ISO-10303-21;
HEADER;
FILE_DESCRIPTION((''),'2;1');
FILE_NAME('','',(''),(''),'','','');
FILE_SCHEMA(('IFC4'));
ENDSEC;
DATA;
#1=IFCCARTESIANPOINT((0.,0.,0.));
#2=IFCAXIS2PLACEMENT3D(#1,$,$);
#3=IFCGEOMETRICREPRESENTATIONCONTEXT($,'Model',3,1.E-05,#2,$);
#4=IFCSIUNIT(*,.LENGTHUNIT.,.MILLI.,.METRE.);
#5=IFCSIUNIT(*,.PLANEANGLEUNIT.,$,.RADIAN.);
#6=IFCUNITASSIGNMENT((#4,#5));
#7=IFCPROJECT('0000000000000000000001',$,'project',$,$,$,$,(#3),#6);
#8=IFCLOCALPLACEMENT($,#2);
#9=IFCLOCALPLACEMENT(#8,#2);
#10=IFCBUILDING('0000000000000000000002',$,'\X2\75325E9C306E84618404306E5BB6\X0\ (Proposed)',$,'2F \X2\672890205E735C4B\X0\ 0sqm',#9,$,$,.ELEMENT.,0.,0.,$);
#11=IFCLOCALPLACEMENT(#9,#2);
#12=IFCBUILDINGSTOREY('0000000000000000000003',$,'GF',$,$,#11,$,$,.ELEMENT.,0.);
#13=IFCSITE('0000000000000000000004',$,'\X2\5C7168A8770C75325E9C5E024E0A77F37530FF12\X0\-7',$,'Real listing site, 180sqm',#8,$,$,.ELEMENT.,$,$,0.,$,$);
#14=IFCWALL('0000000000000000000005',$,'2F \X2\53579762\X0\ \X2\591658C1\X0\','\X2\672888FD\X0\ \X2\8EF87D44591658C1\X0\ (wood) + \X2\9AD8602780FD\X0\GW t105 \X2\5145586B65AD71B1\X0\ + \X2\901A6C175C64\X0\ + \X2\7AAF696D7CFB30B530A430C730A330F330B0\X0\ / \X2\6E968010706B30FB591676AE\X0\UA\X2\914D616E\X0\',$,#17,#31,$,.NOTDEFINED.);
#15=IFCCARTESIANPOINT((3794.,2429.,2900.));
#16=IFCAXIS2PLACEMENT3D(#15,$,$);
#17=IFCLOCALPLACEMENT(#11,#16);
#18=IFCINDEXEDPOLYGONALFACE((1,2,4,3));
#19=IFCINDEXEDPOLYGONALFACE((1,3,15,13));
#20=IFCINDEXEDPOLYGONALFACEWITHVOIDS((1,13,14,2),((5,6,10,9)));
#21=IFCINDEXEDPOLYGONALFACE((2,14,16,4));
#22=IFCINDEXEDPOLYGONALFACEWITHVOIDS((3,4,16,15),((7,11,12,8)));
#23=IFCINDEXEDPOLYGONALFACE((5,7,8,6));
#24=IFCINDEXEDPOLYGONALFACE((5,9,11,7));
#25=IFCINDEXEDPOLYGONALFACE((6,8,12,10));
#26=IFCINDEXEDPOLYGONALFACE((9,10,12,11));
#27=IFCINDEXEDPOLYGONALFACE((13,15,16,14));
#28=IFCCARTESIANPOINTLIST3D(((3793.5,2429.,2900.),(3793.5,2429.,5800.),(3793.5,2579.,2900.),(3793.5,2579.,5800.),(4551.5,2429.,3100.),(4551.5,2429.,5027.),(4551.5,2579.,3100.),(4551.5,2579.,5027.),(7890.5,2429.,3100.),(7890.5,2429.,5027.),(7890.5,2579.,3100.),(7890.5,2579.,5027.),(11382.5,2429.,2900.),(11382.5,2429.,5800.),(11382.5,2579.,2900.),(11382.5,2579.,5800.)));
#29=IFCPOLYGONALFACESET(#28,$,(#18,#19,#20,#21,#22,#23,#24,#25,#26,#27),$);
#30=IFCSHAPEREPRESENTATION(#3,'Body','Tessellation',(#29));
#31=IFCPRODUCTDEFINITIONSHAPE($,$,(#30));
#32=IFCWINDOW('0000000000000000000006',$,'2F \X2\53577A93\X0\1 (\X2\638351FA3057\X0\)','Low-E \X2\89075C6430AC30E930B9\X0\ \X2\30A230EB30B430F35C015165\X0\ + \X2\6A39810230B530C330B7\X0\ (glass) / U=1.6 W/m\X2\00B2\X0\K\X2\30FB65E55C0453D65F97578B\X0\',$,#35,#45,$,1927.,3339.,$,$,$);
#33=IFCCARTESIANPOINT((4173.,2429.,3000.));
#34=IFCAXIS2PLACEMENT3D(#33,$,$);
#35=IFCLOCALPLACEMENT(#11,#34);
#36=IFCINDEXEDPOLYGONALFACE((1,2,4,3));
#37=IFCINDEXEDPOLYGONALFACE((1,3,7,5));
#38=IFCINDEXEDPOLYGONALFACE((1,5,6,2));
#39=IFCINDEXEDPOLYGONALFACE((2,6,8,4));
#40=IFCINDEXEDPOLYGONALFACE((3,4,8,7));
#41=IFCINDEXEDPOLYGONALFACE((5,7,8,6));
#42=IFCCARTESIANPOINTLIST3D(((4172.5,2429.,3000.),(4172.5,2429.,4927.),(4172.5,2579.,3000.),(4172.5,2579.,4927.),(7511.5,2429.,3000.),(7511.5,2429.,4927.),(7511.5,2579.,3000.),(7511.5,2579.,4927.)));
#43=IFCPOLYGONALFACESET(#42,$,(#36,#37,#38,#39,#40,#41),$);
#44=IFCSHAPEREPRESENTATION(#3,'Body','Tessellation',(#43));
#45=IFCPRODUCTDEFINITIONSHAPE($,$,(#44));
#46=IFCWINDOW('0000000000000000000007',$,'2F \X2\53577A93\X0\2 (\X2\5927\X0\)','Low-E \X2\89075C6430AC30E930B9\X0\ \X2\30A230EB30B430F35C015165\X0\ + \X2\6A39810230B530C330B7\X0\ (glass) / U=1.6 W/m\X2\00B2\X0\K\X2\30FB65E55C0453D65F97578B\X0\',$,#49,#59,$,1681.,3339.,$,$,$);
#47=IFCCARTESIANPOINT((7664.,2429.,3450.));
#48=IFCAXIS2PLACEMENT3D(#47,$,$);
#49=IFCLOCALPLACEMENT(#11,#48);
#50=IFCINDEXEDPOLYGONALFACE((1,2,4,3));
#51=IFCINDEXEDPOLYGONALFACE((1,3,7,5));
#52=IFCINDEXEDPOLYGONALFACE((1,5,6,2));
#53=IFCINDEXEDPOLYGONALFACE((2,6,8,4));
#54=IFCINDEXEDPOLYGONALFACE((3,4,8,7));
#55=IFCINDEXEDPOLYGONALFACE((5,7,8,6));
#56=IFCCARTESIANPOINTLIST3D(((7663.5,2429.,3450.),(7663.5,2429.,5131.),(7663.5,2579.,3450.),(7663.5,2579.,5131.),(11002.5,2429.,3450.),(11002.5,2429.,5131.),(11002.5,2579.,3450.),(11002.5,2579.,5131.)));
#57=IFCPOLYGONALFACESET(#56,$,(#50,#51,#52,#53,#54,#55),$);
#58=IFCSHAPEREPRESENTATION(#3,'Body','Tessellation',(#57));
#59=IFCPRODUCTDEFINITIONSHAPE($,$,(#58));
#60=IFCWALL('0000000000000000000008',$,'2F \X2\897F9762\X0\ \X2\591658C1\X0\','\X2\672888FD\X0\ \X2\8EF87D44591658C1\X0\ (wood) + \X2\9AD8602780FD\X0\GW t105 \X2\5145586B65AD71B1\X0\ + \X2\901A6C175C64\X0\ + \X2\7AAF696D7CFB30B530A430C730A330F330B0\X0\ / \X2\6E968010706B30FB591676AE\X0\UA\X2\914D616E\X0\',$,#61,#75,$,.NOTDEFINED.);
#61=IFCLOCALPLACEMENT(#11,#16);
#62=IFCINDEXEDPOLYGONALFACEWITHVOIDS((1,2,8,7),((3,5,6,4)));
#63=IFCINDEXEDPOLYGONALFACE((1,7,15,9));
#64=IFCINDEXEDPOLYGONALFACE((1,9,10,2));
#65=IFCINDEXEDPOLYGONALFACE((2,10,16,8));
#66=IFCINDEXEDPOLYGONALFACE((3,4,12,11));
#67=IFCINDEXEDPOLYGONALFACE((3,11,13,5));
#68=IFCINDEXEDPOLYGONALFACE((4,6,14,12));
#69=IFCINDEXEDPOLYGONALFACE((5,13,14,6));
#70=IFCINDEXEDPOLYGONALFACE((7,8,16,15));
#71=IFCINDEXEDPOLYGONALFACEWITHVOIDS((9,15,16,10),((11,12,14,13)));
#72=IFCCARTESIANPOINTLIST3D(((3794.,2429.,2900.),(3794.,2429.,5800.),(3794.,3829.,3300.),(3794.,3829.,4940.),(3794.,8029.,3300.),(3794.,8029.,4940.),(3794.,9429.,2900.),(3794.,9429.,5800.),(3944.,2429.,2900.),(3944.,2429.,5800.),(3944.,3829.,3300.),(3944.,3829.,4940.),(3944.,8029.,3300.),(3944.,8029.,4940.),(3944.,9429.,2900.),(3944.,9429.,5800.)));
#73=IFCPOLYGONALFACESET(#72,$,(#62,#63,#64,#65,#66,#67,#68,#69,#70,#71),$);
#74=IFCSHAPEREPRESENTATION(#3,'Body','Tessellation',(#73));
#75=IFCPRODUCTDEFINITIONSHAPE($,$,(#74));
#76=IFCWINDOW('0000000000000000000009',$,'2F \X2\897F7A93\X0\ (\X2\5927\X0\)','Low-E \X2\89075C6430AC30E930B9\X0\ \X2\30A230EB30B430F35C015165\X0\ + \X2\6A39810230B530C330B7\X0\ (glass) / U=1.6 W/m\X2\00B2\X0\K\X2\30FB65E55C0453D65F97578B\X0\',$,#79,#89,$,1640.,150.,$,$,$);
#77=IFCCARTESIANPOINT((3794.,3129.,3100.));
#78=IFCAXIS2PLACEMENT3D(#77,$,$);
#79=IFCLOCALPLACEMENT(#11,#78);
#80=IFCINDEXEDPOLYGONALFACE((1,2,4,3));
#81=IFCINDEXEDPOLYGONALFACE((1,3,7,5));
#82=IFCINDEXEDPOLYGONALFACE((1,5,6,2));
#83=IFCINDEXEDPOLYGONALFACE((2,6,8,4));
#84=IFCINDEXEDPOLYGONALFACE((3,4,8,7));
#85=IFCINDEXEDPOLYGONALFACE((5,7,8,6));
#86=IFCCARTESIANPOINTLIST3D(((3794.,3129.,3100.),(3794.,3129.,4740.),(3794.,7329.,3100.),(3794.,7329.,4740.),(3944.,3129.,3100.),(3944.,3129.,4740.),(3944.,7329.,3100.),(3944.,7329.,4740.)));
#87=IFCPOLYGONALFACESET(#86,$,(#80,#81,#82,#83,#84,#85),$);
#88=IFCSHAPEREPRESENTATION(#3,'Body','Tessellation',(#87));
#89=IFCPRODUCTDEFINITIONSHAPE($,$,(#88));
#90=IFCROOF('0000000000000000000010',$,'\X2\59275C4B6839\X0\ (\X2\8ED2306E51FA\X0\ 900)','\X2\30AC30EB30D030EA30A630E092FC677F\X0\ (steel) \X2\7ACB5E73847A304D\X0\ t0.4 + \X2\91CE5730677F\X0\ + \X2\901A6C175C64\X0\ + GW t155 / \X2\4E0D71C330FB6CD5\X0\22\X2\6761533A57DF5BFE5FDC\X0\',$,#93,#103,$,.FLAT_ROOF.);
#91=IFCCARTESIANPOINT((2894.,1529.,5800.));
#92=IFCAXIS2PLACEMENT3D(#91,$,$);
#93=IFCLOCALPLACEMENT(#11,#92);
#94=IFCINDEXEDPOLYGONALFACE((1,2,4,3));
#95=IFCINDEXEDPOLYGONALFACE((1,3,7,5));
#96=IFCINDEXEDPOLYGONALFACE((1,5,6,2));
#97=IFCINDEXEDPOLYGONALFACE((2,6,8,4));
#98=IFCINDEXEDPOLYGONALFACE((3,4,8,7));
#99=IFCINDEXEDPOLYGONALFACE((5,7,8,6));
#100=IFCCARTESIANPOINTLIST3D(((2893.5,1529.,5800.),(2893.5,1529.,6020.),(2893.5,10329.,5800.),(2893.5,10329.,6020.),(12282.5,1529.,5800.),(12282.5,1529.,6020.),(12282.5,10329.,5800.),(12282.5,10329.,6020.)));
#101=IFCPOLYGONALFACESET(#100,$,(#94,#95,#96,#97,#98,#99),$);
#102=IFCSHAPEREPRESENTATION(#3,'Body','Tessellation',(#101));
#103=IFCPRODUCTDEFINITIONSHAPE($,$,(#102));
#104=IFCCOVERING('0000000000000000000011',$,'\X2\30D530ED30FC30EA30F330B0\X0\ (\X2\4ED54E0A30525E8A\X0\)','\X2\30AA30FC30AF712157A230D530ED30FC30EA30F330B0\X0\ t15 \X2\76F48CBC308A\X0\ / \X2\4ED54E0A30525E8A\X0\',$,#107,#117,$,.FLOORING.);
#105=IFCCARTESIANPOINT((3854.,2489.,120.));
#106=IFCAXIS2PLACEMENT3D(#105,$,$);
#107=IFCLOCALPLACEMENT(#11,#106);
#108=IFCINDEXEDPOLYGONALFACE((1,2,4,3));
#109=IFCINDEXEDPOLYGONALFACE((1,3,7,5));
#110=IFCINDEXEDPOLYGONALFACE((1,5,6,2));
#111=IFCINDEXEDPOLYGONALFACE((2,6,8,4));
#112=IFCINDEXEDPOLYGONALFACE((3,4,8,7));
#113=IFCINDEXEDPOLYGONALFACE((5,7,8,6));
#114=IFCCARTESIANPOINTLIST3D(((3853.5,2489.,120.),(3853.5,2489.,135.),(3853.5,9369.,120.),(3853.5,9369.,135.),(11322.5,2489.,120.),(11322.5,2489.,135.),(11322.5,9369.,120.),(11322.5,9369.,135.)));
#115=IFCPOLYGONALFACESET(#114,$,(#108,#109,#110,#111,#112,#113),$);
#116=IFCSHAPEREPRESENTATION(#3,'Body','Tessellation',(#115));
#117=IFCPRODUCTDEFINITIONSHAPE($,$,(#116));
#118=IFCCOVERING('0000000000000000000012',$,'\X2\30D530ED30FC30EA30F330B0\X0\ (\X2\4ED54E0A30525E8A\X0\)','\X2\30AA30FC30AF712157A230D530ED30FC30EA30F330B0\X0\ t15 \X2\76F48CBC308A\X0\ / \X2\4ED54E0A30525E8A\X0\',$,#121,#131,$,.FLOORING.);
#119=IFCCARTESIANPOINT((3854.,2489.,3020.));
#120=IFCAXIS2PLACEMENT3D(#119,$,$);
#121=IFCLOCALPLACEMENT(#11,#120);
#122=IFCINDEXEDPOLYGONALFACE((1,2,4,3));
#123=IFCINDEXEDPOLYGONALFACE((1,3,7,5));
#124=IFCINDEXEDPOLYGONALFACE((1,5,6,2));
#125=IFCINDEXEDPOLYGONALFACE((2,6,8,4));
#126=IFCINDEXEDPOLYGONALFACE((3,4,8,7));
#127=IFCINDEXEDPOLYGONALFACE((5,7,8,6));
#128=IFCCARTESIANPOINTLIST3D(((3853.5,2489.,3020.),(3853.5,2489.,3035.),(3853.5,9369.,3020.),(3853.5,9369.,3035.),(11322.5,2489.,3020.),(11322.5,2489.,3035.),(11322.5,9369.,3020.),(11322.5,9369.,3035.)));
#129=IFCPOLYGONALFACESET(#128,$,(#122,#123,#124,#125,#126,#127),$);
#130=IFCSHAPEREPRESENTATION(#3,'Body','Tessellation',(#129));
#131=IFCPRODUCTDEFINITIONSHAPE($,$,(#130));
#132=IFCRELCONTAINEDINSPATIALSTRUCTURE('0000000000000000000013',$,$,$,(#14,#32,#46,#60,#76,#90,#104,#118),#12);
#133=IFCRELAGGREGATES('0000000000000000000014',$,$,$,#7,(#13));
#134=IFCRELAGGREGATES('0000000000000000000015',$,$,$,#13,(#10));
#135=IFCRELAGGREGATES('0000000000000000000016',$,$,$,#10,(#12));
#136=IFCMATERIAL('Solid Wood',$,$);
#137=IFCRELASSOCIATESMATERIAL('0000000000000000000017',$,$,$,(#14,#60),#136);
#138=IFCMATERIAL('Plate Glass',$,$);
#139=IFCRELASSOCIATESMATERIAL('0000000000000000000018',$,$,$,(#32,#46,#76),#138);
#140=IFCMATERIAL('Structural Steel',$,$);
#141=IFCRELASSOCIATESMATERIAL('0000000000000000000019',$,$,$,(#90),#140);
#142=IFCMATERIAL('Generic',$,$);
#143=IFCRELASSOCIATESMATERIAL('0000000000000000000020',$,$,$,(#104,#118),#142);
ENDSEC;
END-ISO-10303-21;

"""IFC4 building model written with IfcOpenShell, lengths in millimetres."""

from ifc_helpers import new_model, si_unit, frame, frame_2d, origin, place, context, project, spatial, rectangle, extrude, material, element, fill, save


model = new_model("IFC4")

# Units and contexts
model_context = context("Model", 3, precision=1e-05, world=origin())
ifc_project = project(units=[si_unit("LENGTHUNIT", "METRE", prefix="MILLI"), si_unit("PLANEANGLEUNIT", "RADIAN")], contexts=[model_context])

# Site, building, storey
site_placement = place(None, origin())
site = spatial("IfcSite", under=ifc_project, at=site_placement, Name="山梨県甲府市上石田２-7", ObjectType="Real listing site, 180sqm", CompositionType="ELEMENT", RefElevation=0.0)
building_placement = place(site_placement, origin())
building = spatial("IfcBuilding", under=site, at=building_placement, Name="甲府の葡萄の家 (Proposed)", ObjectType="2F 木造平屋 0sqm", CompositionType="ELEMENT", ElevationOfRefHeight=0.0, ElevationOfTerrain=0.0)
storey_placement = place(building_placement, origin())
storey = spatial("IfcBuildingStorey", under=building, at=storey_placement, Name="GF", CompositionType="ELEMENT", Elevation=0.0)

# Shared definitions
ifc_material_1 = material(Name="Solid Wood")

# Shared definitions
ifc_material_2 = material(Name="Plate Glass")

# Wall, openings, windows
wall_1_placement = place(storey_placement, frame((3794.0, 2429.0, 2900.0)))
wall_1 = element("IfcWall", 1, at=wall_1_placement, inside=storey, material=ifc_material_1, Name="2F 南面 外壁", Description="木製 軸組外壁 (wood) + 高性能GW t105 充填断熱 + 通気層 + 窯業系サイディング / 準耐火・外皮UA配慮", PredefinedType="NOTDEFINED", context=model_context, shape_type="SweptSolid", body=[
    extrude(rectangle(XDim=7589.0, YDim=150.0, at=frame_2d((3794.0, 75.0))), frame((3794.0, 2429.0, 2900.0)), (0.0, 0.0, 1.0), 2900.0),
])
opening_1_placement = place(storey_placement, frame((4173.0, 2429.0, 3000.0)))
opening_1 = element("IfcOpeningElement", 2, at=opening_1_placement, cuts=wall_1, PredefinedType="NOTDEFINED", context=model_context, shape_type="SweptSolid", body=[
    extrude(rectangle(XDim=3339.0, YDim=150.0, at=frame_2d((1669.0, 75.0))), frame((4173.0, 2429.0, 3000.0)), (0.0, 0.0, 1.0), 1927.0),
])
opening_2_placement = place(storey_placement, frame((7664.0, 2429.0, 3450.0)))
opening_2 = element("IfcOpeningElement", 3, at=opening_2_placement, cuts=wall_1, PredefinedType="NOTDEFINED", context=model_context, shape_type="SweptSolid", body=[
    extrude(rectangle(XDim=3339.0, YDim=150.0, at=frame_2d((1669.0, 75.0))), frame((7664.0, 2429.0, 3450.0)), (0.0, 0.0, 1.0), 1681.0),
])
window_1_placement = place(storey_placement, frame((4173.0, 2429.0, 3000.0)))
window_1 = element("IfcWindow", 4, at=window_1_placement, inside=storey, material=ifc_material_2, Name="2F 南窓1 (掃出し)", Description="Low-E 複層ガラス アルゴン封入 + 樹脂サッシ (glass) / U=1.6 W/m²K・日射取得型", OverallHeight=1927.0, OverallWidth=3339.0, context=model_context, shape_type="SweptSolid", body=[
    extrude(rectangle(XDim=3339.0, YDim=150.0, at=frame_2d((1669.0, 75.0))), frame((4173.0, 2429.0, 3000.0)), (0.0, 0.0, 1.0), 1927.0),
])
fill(opening_1, window_1)
window_2_placement = place(storey_placement, frame((7664.0, 2429.0, 3450.0)))
window_2 = element("IfcWindow", 5, at=window_2_placement, inside=storey, material=ifc_material_2, Name="2F 南窓2 (大)", Description="Low-E 複層ガラス アルゴン封入 + 樹脂サッシ (glass) / U=1.6 W/m²K・日射取得型", OverallHeight=1681.0, OverallWidth=3339.0, context=model_context, shape_type="SweptSolid", body=[
    extrude(rectangle(XDim=3339.0, YDim=150.0, at=frame_2d((1669.0, 75.0))), frame((7664.0, 2429.0, 3450.0)), (0.0, 0.0, 1.0), 1681.0),
])
fill(opening_2, window_2)

# Wall, opening, window
wall_2_placement = place(storey_placement, frame((3794.0, 2429.0, 2900.0)))
wall_2 = element("IfcWall", 6, at=wall_2_placement, inside=storey, material=ifc_material_1, Name="2F 西面 外壁", Description="木製 軸組外壁 (wood) + 高性能GW t105 充填断熱 + 通気層 + 窯業系サイディング / 準耐火・外皮UA配慮", PredefinedType="NOTDEFINED", context=model_context, shape_type="SweptSolid", body=[
    extrude(rectangle(XDim=150.0, YDim=7000.0, at=frame_2d((75.0, 3500.0))), frame((3794.0, 2429.0, 2900.0)), (0.0, 0.0, 1.0), 2900.0),
])
opening_3_placement = place(storey_placement, frame((3794.0, 3129.0, 3100.0)))
opening_3 = element("IfcOpeningElement", 7, at=opening_3_placement, cuts=wall_2, PredefinedType="NOTDEFINED", context=model_context, shape_type="SweptSolid", body=[
    extrude(rectangle(XDim=150.0, YDim=4200.0, at=frame_2d((75.0, 2100.0))), frame((3794.0, 3129.0, 3100.0)), (0.0, 0.0, 1.0), 1640.0),
])
window_3_placement = place(storey_placement, frame((3794.0, 3129.0, 3100.0)))
window_3 = element("IfcWindow", 8, at=window_3_placement, inside=storey, material=ifc_material_2, Name="2F 西窓 (大)", Description="Low-E 複層ガラス アルゴン封入 + 樹脂サッシ (glass) / U=1.6 W/m²K・日射取得型", OverallHeight=1640.0, OverallWidth=150.0, context=model_context, shape_type="SweptSolid", body=[
    extrude(rectangle(XDim=150.0, YDim=4200.0, at=frame_2d((75.0, 2100.0))), frame((3794.0, 3129.0, 3100.0)), (0.0, 0.0, 1.0), 1640.0),
])
fill(opening_3, window_3)

# Roof
ifc_material_3 = material(Name="Structural Steel")
roof_placement = place(storey_placement, frame((2894.0, 1529.0, 5800.0)))
element("IfcRoof", 9, at=roof_placement, inside=storey, material=ifc_material_3, Name="大屋根 (軒の出 900)", Description="ガルバリウム鋼板 (steel) 立平葺き t0.4 + 野地板 + 通気層 + GW t155 / 不燃・法22条区域対応", PredefinedType="FLAT_ROOF", context=model_context, shape_type="SweptSolid", body=[
    extrude(rectangle(XDim=9389.0, YDim=8800.0, at=frame_2d((4694.0, 4400.0))), frame((2894.0, 1529.0, 5800.0)), (0.0, 0.0, 1.0), 220.0),
])

# Coverings
ifc_material_4 = material(Name="Generic")
covering_1_placement = place(storey_placement, frame((3854.0, 2489.0, 120.0)))
element("IfcCovering", 10, at=covering_1_placement, inside=storey, material=ifc_material_4, Name="フローリング (仕上げ床)", Description="オーク無垢フローリング t15 直貼り / 仕上げ床", PredefinedType="FLOORING", context=model_context, shape_type="SweptSolid", body=[
    extrude(rectangle(XDim=7469.0, YDim=6880.0, at=frame_2d((3734.0, 3440.0))), frame((3854.0, 2489.0, 120.0)), (0.0, 0.0, 1.0), 15.0),
])
covering_2_placement = place(storey_placement, frame((3854.0, 2489.0, 3020.0)))
element("IfcCovering", 11, at=covering_2_placement, inside=storey, material=ifc_material_4, Name="フローリング (仕上げ床)", Description="オーク無垢フローリング t15 直貼り / 仕上げ床", PredefinedType="FLOORING", context=model_context, shape_type="SweptSolid", body=[
    extrude(rectangle(XDim=7469.0, YDim=6880.0, at=frame_2d((3734.0, 3440.0))), frame((3854.0, 2489.0, 3020.0)), (0.0, 0.0, 1.0), 15.0),
])

save(model, "model.ifc")
